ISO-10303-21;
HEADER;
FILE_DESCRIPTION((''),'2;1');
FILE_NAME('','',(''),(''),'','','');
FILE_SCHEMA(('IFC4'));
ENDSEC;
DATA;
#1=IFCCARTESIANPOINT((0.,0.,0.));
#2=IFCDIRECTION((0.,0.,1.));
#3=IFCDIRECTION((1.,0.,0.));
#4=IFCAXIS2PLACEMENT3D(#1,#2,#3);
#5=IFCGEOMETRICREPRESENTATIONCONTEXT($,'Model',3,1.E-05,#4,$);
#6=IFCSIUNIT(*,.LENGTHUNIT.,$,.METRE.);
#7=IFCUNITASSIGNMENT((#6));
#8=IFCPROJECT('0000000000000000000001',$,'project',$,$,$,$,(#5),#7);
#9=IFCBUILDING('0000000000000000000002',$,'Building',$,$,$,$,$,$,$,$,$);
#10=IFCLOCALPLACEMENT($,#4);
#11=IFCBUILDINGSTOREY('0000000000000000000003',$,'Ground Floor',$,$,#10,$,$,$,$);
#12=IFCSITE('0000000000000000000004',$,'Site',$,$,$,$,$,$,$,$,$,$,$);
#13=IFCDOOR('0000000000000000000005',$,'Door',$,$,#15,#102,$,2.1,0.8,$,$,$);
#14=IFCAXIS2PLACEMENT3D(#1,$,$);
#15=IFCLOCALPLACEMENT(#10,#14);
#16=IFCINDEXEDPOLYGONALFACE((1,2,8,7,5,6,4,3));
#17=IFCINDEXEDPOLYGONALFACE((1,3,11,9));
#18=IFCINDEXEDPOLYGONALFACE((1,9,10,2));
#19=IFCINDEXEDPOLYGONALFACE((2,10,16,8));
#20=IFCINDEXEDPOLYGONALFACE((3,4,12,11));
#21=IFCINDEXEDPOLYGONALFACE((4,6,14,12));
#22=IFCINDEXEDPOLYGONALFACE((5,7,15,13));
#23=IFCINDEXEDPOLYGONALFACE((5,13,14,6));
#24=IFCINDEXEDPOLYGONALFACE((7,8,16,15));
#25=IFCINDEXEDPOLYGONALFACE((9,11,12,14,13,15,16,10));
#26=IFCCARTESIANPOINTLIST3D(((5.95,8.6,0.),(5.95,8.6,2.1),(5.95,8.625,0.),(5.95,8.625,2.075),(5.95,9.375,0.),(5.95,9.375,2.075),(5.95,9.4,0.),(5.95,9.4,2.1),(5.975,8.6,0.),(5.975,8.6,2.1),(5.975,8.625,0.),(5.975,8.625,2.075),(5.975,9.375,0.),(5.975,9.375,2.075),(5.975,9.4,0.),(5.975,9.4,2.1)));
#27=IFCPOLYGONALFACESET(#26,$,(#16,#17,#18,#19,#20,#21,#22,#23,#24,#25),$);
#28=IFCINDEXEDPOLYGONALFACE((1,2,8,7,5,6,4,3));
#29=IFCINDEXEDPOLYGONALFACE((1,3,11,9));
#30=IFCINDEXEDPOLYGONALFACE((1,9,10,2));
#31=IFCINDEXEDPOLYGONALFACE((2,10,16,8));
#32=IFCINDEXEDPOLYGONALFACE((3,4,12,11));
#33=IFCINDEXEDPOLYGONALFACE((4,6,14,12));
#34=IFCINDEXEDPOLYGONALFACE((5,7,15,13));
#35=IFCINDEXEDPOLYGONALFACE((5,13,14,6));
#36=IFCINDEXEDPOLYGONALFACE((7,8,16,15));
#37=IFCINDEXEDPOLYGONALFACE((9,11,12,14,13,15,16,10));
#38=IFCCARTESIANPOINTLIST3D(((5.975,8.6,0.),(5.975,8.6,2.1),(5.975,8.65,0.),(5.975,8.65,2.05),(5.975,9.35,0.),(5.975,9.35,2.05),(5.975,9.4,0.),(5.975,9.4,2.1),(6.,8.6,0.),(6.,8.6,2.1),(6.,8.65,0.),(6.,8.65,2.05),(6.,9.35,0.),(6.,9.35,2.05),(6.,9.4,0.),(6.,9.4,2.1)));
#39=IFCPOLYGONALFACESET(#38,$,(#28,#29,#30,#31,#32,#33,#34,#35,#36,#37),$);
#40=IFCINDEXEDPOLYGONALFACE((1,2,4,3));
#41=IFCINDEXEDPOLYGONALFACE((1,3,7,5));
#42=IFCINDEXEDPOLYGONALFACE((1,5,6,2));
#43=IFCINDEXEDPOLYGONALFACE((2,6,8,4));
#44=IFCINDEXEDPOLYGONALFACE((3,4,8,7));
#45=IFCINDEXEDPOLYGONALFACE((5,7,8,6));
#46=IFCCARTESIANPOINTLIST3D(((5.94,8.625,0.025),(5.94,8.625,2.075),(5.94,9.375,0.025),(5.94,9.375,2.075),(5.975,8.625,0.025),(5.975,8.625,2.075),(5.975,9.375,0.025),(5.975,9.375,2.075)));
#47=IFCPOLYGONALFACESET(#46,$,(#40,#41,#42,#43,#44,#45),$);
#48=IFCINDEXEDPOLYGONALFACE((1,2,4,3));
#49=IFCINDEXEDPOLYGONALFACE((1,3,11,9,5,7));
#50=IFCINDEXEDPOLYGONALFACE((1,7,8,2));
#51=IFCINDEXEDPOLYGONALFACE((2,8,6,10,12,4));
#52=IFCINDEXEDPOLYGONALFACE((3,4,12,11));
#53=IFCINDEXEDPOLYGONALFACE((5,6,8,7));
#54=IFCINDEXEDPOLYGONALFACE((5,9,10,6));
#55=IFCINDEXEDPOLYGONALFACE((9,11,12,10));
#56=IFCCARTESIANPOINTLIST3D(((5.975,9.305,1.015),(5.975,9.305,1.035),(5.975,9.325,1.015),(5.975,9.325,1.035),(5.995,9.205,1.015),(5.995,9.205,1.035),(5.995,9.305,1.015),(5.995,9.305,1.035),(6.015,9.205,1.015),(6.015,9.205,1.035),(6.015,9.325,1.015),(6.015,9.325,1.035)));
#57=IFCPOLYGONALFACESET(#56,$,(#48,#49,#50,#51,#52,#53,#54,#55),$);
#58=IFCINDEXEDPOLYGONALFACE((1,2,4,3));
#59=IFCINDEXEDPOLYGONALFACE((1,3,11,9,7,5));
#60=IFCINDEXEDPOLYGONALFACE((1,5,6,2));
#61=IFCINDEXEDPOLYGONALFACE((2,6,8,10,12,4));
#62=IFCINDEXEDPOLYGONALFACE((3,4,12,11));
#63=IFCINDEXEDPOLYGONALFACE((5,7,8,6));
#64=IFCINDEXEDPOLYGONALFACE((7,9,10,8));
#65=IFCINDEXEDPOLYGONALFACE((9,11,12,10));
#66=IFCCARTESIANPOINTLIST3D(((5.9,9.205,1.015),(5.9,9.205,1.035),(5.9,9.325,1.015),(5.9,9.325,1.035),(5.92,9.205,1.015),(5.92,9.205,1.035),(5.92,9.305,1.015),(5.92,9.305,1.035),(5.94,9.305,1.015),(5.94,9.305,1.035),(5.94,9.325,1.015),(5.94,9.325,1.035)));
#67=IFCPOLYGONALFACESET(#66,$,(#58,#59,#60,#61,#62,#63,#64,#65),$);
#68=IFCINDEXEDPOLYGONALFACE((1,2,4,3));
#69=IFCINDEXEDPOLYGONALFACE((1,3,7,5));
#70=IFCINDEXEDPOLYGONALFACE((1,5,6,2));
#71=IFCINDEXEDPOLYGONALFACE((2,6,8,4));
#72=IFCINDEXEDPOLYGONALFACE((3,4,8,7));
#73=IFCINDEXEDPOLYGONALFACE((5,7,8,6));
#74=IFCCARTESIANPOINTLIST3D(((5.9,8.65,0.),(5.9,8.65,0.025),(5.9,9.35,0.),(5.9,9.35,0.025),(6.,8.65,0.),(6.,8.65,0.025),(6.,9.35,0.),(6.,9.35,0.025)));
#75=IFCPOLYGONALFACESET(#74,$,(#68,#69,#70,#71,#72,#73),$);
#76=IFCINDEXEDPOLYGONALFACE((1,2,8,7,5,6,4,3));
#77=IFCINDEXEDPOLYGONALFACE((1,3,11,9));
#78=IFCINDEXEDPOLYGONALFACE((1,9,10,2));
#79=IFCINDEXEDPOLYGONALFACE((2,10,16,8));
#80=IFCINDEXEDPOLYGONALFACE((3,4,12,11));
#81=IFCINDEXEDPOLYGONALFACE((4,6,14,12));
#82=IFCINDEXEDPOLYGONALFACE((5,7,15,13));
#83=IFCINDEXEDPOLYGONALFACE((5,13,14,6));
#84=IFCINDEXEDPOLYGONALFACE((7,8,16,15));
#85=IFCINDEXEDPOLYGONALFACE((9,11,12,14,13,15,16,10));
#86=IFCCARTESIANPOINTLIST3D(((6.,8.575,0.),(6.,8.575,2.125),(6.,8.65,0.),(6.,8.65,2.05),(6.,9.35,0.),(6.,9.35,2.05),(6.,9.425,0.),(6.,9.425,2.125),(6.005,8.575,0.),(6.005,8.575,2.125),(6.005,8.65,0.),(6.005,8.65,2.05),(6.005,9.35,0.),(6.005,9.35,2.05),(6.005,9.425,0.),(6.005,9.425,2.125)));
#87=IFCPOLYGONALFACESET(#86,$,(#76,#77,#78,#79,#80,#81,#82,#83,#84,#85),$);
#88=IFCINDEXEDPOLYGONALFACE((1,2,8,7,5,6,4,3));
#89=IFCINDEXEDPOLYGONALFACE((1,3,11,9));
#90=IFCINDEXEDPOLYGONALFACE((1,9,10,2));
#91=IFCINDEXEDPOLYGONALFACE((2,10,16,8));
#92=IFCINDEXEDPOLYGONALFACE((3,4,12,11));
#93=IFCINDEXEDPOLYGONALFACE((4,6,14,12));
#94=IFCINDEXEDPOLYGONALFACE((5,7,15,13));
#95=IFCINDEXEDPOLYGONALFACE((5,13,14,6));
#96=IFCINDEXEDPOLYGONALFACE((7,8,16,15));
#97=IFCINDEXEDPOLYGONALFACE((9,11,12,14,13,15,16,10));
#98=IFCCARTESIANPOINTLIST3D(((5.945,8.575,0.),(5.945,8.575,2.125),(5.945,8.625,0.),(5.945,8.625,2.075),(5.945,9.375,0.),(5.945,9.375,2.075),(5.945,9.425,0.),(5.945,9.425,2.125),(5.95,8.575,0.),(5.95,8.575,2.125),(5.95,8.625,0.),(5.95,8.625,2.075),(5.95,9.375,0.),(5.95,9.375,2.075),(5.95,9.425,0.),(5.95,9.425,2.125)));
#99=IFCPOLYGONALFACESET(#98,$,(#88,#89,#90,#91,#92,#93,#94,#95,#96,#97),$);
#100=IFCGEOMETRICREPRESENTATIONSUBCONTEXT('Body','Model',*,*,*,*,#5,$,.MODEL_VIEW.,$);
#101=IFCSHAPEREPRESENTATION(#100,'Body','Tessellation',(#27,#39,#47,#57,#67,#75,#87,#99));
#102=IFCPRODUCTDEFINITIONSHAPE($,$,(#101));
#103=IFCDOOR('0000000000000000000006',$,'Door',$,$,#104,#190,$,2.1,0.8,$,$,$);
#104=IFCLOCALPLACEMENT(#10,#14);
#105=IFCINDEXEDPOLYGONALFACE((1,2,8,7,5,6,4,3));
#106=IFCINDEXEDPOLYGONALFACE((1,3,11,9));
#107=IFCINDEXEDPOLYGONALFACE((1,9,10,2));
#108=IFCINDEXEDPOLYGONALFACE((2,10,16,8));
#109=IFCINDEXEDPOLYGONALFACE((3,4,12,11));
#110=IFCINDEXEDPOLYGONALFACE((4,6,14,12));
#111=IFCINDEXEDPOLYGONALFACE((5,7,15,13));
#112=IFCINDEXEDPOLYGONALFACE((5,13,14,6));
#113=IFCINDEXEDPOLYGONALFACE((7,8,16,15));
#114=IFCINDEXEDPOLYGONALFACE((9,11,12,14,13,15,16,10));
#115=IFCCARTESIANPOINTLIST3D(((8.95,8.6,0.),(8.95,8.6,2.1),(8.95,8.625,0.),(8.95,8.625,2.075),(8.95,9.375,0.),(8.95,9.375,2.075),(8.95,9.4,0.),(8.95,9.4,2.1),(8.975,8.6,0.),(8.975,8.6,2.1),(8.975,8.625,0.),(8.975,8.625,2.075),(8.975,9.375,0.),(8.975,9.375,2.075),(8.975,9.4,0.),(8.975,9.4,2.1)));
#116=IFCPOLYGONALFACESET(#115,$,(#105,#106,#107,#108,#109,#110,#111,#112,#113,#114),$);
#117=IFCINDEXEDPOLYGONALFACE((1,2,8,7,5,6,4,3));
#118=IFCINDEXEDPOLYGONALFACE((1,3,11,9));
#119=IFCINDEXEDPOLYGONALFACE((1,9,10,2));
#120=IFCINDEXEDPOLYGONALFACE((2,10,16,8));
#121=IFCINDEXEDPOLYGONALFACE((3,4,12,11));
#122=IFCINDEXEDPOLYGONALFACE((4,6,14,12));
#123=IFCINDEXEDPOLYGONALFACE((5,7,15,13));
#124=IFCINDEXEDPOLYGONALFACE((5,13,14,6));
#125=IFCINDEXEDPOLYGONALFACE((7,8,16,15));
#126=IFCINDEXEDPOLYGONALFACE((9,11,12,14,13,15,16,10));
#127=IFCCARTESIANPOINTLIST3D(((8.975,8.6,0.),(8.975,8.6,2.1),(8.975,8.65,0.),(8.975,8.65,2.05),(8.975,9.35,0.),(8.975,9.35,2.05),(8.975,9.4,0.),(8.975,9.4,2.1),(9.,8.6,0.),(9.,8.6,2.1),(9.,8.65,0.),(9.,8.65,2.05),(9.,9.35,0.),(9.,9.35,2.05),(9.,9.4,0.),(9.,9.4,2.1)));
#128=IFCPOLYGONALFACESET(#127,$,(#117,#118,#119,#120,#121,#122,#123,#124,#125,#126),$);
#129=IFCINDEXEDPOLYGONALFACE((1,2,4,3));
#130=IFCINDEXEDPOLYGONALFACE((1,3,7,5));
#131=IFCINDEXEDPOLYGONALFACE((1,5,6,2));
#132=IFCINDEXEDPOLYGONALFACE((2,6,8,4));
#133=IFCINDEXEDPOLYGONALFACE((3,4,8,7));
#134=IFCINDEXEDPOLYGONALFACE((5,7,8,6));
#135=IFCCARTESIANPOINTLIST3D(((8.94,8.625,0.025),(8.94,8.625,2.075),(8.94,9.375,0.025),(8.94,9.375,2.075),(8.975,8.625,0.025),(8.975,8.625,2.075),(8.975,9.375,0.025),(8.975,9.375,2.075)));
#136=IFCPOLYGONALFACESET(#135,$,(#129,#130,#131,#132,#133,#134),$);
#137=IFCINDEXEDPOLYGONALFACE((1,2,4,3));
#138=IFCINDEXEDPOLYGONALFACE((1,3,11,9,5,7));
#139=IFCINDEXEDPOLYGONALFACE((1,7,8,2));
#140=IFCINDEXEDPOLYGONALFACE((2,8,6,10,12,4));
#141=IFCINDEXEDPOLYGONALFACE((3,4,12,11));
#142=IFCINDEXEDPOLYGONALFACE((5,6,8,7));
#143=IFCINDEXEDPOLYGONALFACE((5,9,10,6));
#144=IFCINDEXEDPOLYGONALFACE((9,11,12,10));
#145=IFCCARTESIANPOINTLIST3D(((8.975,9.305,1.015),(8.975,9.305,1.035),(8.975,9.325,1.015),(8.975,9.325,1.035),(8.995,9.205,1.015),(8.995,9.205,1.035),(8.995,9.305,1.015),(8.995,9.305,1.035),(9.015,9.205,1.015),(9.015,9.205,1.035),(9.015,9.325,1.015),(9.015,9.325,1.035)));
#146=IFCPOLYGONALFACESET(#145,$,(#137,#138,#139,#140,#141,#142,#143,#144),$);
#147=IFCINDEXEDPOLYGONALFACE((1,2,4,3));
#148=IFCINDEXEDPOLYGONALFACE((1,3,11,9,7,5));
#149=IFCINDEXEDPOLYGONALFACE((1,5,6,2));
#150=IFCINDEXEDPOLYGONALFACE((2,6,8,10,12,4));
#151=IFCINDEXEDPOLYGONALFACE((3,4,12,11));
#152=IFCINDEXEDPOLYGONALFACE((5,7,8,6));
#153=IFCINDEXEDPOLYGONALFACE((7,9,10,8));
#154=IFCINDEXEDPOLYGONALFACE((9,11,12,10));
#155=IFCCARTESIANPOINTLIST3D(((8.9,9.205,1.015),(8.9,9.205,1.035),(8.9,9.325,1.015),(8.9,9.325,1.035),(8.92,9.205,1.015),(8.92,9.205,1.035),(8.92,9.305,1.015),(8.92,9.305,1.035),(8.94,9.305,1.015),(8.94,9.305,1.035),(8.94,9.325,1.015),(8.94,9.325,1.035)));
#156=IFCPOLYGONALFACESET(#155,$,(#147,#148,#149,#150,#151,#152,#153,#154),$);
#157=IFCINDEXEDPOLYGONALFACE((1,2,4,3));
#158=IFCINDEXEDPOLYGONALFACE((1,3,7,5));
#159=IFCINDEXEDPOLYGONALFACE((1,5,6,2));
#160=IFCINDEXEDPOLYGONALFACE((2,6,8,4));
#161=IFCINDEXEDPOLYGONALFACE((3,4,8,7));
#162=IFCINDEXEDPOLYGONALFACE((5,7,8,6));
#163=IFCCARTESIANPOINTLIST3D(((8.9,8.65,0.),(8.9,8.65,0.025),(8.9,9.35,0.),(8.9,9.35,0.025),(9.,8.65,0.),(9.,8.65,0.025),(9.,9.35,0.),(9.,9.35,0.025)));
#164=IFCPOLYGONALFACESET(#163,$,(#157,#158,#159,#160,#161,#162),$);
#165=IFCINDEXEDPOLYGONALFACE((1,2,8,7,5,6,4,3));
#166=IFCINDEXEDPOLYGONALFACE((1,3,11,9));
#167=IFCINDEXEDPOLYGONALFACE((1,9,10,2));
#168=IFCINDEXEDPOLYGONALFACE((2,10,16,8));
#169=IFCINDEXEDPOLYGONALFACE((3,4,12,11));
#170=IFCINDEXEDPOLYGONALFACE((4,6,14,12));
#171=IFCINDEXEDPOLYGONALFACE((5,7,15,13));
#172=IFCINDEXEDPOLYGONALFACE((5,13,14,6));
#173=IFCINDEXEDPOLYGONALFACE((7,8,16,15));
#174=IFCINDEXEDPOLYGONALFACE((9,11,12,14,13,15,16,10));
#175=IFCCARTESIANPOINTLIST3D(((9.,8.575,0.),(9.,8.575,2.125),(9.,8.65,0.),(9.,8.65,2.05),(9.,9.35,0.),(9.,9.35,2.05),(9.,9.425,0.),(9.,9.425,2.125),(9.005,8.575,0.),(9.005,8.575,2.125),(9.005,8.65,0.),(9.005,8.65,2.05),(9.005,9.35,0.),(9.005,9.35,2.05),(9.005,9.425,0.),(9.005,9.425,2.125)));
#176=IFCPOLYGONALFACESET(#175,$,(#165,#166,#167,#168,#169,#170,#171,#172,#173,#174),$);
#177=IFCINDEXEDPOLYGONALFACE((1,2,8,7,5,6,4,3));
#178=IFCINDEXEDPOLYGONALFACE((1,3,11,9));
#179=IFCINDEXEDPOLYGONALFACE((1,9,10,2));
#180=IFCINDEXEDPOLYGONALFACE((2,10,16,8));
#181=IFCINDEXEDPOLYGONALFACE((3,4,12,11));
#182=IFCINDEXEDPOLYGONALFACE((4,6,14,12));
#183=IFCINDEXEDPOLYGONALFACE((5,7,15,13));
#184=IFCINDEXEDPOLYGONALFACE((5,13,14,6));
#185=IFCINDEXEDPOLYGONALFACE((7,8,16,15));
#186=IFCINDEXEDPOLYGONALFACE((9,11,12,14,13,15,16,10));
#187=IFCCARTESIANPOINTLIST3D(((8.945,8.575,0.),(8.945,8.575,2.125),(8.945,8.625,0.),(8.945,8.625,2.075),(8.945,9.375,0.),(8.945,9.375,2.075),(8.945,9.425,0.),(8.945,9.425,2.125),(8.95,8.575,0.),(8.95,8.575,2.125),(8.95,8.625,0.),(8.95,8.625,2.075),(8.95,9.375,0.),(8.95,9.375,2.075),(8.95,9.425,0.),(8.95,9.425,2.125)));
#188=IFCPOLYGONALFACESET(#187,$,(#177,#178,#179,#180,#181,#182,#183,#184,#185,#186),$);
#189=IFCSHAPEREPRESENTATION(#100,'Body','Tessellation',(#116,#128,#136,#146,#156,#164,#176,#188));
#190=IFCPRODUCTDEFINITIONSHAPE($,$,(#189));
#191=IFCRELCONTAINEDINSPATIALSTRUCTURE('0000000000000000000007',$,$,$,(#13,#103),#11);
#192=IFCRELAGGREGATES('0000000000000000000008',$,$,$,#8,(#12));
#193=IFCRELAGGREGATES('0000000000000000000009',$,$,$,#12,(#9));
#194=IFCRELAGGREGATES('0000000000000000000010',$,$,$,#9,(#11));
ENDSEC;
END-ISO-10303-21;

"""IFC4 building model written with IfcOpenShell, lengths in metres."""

from ifc_helpers import new_model, si_unit, frame, origin_with_axes, place, context, subcontext, project, spatial, line, indexed_curve, outline, extrude, element, save


model = new_model("IFC4")

# Units and contexts
model_context = context("Model", 3, precision=1e-05, world=origin_with_axes())
body_context = subcontext(model_context, "Body", "Model", "MODEL_VIEW")
ifc_project = project(units=[si_unit("LENGTHUNIT", "METRE")], contexts=[model_context])

# Site, building, storey
site = spatial("IfcSite", under=ifc_project, Name="Site")
building = spatial("IfcBuilding", under=site, Name="Building")
storey_placement = place(None, origin_with_axes())
storey = spatial("IfcBuildingStorey", under=building, at=storey_placement, Name="Ground Floor")

# Doors
door_1_placement = place(storey_placement, frame((6.0, 8.6, 0.0), z_axis=(0.0, 0.0, 1.0), x_axis=(0.0, 1.0, 0.0)))
element("IfcDoor", 1, at=door_1_placement, inside=storey, Name="Door", OverallHeight=2.1, OverallWidth=0.8, context=body_context, shape_type="SweptSolid", body=[
    extrude(outline(indexed_curve([(0.0, 0.0), (0.0, 2.1), (0.8, 2.1), (0.8, 0.0), (0.775, 0.0), (0.775, 2.075), (0.025, 2.075), (0.025, 0.0)], segments=[line(1, 2, 3, 4, 5, 6, 7, 8, 1)])), frame((0.0, 0.025, 0.0), z_axis=(0.0, -1.0, 0.0), x_axis=(1.0, 0.0, 0.0)), (0.0, 0.0, -1.0), 0.025),
    extrude(outline(indexed_curve([(0.0, 0.0), (0.0, 2.1), (0.8, 2.1), (0.8, 0.0), (0.75, 0.0), (0.75, 2.05), (0.05, 2.05), (0.05, 0.0)], segments=[line(1, 2, 3, 4, 5, 6, 7, 8, 1)])), frame((0.0, 0.0, 0.0), z_axis=(0.0, -1.0, 0.0), x_axis=(1.0, 0.0, 0.0)), (0.0, 0.0, -1.0), 0.025),
    extrude(outline(indexed_curve([(0.0, 0.0), (0.75, 0.0), (0.75, 0.035), (0.0, 0.035)], segments=[line(1, 2, 3, 4, 1)])), frame((0.025, 0.025, 0.025), z_axis=(0.0, 0.0, 1.0), x_axis=(1.0, 0.0, 0.0)), (0.0, 0.0, 1.0), 2.05),
    extrude(outline(indexed_curve([(0.0, 0.0), (0.0, -0.04), (-0.12, -0.04), (-0.12, -0.02), (-0.02, -0.02), (-0.02, 0.0)], segments=[line(1, 2, 3, 4, 5, 6, 1)])), frame((0.725, 0.025, 1.015), z_axis=(0.0, 0.0, 1.0), x_axis=(1.0, 0.0, 0.0)), (0.0, 0.0, 1.0), 0.02),
    extrude(outline(indexed_curve([(0.0, 0.0), (0.0, 0.04), (-0.12, 0.04), (-0.12, 0.02), (-0.02, 0.02), (-0.02, 0.0)], segments=[line(1, 2, 3, 4, 5, 6, 1)])), frame((0.725, 0.06, 1.015), z_axis=(0.0, 0.0, 1.0), x_axis=(1.0, 0.0, 0.0)), (0.0, 0.0, 1.0), 0.02),
    extrude(outline(indexed_curve([(0.0, 0.0), (0.7, 0.0), (0.7, 0.1), (0.0, 0.1)], segments=[line(1, 2, 3, 4, 1)])), frame((0.05, 0.0, 0.0), z_axis=(0.0, 0.0, 1.0), x_axis=(1.0, 0.0, 0.0)), (0.0, 0.0, 1.0), 0.025),
    extrude(outline(indexed_curve([(0.0, 0.0), (0.0, 2.125), (0.85, 2.125), (0.85, 0.0), (0.775, 0.0), (0.775, 2.05), (0.075, 2.05), (0.075, 0.0)], segments=[line(1, 2, 3, 4, 5, 6, 7, 8, 1)])), frame((-0.025, -0.005, 0.0), z_axis=(0.0, -1.0, 0.0), x_axis=(1.0, 0.0, 0.0)), (0.0, 0.0, -1.0), 0.005),
    extrude(outline(indexed_curve([(0.0, 0.0), (0.0, 2.125), (0.85, 2.125), (0.85, 0.0), (0.8, 0.0), (0.8, 2.075), (0.05, 2.075), (0.05, 0.0)], segments=[line(1, 2, 3, 4, 5, 6, 7, 8, 1)])), frame((-0.025, 0.05, 0.0), z_axis=(0.0, -1.0, 0.0), x_axis=(1.0, 0.0, 0.0)), (0.0, 0.0, -1.0), 0.005),
])
door_2_placement = place(storey_placement, frame((9.0, 8.6, 0.0), z_axis=(0.0, 0.0, 1.0), x_axis=(0.0, 1.0, 0.0)))
element("IfcDoor", 2, at=door_2_placement, inside=storey, Name="Door", OverallHeight=2.1, OverallWidth=0.8, context=body_context, shape_type="SweptSolid", body=[
    extrude(outline(indexed_curve([(0.0, 0.0), (0.0, 2.1), (0.8, 2.1), (0.8, 0.0), (0.775, 0.0), (0.775, 2.075), (0.025, 2.075), (0.025, 0.0)], segments=[line(1, 2, 3, 4, 5, 6, 7, 8, 1)])), frame((0.0, 0.025, 0.0), z_axis=(0.0, -1.0, 0.0), x_axis=(1.0, 0.0, 0.0)), (0.0, 0.0, -1.0), 0.025),
    extrude(outline(indexed_curve([(0.0, 0.0), (0.0, 2.1), (0.8, 2.1), (0.8, 0.0), (0.75, 0.0), (0.75, 2.05), (0.05, 2.05), (0.05, 0.0)], segments=[line(1, 2, 3, 4, 5, 6, 7, 8, 1)])), frame((0.0, 0.0, 0.0), z_axis=(0.0, -1.0, 0.0), x_axis=(1.0, 0.0, 0.0)), (0.0, 0.0, -1.0), 0.025),
    extrude(outline(indexed_curve([(0.0, 0.0), (0.75, 0.0), (0.75, 0.035), (0.0, 0.035)], segments=[line(1, 2, 3, 4, 1)])), frame((0.025, 0.025, 0.025), z_axis=(0.0, 0.0, 1.0), x_axis=(1.0, 0.0, 0.0)), (0.0, 0.0, 1.0), 2.05),
    extrude(outline(indexed_curve([(0.0, 0.0), (0.0, -0.04), (-0.12, -0.04), (-0.12, -0.02), (-0.02, -0.02), (-0.02, 0.0)], segments=[line(1, 2, 3, 4, 5, 6, 1)])), frame((0.725, 0.025, 1.015), z_axis=(0.0, 0.0, 1.0), x_axis=(1.0, 0.0, 0.0)), (0.0, 0.0, 1.0), 0.02),
    extrude(outline(indexed_curve([(0.0, 0.0), (0.0, 0.04), (-0.12, 0.04), (-0.12, 0.02), (-0.02, 0.02), (-0.02, 0.0)], segments=[line(1, 2, 3, 4, 5, 6, 1)])), frame((0.725, 0.06, 1.015), z_axis=(0.0, 0.0, 1.0), x_axis=(1.0, 0.0, 0.0)), (0.0, 0.0, 1.0), 0.02),
    extrude(outline(indexed_curve([(0.0, 0.0), (0.7, 0.0), (0.7, 0.1), (0.0, 0.1)], segments=[line(1, 2, 3, 4, 1)])), frame((0.05, 0.0, 0.0), z_axis=(0.0, 0.0, 1.0), x_axis=(1.0, 0.0, 0.0)), (0.0, 0.0, 1.0), 0.025),
    extrude(outline(indexed_curve([(0.0, 0.0), (0.0, 2.125), (0.85, 2.125), (0.85, 0.0), (0.775, 0.0), (0.775, 2.05), (0.075, 2.05), (0.075, 0.0)], segments=[line(1, 2, 3, 4, 5, 6, 7, 8, 1)])), frame((-0.025, -0.005, 0.0), z_axis=(0.0, -1.0, 0.0), x_axis=(1.0, 0.0, 0.0)), (0.0, 0.0, -1.0), 0.005),
    extrude(outline(indexed_curve([(0.0, 0.0), (0.0, 2.125), (0.85, 2.125), (0.85, 0.0), (0.8, 0.0), (0.8, 2.075), (0.05, 2.075), (0.05, 0.0)], segments=[line(1, 2, 3, 4, 5, 6, 7, 8, 1)])), frame((-0.025, 0.05, 0.0), z_axis=(0.0, -1.0, 0.0), x_axis=(1.0, 0.0, 0.0)), (0.0, 0.0, -1.0), 0.005),
])

save(model, "model.ifc")
